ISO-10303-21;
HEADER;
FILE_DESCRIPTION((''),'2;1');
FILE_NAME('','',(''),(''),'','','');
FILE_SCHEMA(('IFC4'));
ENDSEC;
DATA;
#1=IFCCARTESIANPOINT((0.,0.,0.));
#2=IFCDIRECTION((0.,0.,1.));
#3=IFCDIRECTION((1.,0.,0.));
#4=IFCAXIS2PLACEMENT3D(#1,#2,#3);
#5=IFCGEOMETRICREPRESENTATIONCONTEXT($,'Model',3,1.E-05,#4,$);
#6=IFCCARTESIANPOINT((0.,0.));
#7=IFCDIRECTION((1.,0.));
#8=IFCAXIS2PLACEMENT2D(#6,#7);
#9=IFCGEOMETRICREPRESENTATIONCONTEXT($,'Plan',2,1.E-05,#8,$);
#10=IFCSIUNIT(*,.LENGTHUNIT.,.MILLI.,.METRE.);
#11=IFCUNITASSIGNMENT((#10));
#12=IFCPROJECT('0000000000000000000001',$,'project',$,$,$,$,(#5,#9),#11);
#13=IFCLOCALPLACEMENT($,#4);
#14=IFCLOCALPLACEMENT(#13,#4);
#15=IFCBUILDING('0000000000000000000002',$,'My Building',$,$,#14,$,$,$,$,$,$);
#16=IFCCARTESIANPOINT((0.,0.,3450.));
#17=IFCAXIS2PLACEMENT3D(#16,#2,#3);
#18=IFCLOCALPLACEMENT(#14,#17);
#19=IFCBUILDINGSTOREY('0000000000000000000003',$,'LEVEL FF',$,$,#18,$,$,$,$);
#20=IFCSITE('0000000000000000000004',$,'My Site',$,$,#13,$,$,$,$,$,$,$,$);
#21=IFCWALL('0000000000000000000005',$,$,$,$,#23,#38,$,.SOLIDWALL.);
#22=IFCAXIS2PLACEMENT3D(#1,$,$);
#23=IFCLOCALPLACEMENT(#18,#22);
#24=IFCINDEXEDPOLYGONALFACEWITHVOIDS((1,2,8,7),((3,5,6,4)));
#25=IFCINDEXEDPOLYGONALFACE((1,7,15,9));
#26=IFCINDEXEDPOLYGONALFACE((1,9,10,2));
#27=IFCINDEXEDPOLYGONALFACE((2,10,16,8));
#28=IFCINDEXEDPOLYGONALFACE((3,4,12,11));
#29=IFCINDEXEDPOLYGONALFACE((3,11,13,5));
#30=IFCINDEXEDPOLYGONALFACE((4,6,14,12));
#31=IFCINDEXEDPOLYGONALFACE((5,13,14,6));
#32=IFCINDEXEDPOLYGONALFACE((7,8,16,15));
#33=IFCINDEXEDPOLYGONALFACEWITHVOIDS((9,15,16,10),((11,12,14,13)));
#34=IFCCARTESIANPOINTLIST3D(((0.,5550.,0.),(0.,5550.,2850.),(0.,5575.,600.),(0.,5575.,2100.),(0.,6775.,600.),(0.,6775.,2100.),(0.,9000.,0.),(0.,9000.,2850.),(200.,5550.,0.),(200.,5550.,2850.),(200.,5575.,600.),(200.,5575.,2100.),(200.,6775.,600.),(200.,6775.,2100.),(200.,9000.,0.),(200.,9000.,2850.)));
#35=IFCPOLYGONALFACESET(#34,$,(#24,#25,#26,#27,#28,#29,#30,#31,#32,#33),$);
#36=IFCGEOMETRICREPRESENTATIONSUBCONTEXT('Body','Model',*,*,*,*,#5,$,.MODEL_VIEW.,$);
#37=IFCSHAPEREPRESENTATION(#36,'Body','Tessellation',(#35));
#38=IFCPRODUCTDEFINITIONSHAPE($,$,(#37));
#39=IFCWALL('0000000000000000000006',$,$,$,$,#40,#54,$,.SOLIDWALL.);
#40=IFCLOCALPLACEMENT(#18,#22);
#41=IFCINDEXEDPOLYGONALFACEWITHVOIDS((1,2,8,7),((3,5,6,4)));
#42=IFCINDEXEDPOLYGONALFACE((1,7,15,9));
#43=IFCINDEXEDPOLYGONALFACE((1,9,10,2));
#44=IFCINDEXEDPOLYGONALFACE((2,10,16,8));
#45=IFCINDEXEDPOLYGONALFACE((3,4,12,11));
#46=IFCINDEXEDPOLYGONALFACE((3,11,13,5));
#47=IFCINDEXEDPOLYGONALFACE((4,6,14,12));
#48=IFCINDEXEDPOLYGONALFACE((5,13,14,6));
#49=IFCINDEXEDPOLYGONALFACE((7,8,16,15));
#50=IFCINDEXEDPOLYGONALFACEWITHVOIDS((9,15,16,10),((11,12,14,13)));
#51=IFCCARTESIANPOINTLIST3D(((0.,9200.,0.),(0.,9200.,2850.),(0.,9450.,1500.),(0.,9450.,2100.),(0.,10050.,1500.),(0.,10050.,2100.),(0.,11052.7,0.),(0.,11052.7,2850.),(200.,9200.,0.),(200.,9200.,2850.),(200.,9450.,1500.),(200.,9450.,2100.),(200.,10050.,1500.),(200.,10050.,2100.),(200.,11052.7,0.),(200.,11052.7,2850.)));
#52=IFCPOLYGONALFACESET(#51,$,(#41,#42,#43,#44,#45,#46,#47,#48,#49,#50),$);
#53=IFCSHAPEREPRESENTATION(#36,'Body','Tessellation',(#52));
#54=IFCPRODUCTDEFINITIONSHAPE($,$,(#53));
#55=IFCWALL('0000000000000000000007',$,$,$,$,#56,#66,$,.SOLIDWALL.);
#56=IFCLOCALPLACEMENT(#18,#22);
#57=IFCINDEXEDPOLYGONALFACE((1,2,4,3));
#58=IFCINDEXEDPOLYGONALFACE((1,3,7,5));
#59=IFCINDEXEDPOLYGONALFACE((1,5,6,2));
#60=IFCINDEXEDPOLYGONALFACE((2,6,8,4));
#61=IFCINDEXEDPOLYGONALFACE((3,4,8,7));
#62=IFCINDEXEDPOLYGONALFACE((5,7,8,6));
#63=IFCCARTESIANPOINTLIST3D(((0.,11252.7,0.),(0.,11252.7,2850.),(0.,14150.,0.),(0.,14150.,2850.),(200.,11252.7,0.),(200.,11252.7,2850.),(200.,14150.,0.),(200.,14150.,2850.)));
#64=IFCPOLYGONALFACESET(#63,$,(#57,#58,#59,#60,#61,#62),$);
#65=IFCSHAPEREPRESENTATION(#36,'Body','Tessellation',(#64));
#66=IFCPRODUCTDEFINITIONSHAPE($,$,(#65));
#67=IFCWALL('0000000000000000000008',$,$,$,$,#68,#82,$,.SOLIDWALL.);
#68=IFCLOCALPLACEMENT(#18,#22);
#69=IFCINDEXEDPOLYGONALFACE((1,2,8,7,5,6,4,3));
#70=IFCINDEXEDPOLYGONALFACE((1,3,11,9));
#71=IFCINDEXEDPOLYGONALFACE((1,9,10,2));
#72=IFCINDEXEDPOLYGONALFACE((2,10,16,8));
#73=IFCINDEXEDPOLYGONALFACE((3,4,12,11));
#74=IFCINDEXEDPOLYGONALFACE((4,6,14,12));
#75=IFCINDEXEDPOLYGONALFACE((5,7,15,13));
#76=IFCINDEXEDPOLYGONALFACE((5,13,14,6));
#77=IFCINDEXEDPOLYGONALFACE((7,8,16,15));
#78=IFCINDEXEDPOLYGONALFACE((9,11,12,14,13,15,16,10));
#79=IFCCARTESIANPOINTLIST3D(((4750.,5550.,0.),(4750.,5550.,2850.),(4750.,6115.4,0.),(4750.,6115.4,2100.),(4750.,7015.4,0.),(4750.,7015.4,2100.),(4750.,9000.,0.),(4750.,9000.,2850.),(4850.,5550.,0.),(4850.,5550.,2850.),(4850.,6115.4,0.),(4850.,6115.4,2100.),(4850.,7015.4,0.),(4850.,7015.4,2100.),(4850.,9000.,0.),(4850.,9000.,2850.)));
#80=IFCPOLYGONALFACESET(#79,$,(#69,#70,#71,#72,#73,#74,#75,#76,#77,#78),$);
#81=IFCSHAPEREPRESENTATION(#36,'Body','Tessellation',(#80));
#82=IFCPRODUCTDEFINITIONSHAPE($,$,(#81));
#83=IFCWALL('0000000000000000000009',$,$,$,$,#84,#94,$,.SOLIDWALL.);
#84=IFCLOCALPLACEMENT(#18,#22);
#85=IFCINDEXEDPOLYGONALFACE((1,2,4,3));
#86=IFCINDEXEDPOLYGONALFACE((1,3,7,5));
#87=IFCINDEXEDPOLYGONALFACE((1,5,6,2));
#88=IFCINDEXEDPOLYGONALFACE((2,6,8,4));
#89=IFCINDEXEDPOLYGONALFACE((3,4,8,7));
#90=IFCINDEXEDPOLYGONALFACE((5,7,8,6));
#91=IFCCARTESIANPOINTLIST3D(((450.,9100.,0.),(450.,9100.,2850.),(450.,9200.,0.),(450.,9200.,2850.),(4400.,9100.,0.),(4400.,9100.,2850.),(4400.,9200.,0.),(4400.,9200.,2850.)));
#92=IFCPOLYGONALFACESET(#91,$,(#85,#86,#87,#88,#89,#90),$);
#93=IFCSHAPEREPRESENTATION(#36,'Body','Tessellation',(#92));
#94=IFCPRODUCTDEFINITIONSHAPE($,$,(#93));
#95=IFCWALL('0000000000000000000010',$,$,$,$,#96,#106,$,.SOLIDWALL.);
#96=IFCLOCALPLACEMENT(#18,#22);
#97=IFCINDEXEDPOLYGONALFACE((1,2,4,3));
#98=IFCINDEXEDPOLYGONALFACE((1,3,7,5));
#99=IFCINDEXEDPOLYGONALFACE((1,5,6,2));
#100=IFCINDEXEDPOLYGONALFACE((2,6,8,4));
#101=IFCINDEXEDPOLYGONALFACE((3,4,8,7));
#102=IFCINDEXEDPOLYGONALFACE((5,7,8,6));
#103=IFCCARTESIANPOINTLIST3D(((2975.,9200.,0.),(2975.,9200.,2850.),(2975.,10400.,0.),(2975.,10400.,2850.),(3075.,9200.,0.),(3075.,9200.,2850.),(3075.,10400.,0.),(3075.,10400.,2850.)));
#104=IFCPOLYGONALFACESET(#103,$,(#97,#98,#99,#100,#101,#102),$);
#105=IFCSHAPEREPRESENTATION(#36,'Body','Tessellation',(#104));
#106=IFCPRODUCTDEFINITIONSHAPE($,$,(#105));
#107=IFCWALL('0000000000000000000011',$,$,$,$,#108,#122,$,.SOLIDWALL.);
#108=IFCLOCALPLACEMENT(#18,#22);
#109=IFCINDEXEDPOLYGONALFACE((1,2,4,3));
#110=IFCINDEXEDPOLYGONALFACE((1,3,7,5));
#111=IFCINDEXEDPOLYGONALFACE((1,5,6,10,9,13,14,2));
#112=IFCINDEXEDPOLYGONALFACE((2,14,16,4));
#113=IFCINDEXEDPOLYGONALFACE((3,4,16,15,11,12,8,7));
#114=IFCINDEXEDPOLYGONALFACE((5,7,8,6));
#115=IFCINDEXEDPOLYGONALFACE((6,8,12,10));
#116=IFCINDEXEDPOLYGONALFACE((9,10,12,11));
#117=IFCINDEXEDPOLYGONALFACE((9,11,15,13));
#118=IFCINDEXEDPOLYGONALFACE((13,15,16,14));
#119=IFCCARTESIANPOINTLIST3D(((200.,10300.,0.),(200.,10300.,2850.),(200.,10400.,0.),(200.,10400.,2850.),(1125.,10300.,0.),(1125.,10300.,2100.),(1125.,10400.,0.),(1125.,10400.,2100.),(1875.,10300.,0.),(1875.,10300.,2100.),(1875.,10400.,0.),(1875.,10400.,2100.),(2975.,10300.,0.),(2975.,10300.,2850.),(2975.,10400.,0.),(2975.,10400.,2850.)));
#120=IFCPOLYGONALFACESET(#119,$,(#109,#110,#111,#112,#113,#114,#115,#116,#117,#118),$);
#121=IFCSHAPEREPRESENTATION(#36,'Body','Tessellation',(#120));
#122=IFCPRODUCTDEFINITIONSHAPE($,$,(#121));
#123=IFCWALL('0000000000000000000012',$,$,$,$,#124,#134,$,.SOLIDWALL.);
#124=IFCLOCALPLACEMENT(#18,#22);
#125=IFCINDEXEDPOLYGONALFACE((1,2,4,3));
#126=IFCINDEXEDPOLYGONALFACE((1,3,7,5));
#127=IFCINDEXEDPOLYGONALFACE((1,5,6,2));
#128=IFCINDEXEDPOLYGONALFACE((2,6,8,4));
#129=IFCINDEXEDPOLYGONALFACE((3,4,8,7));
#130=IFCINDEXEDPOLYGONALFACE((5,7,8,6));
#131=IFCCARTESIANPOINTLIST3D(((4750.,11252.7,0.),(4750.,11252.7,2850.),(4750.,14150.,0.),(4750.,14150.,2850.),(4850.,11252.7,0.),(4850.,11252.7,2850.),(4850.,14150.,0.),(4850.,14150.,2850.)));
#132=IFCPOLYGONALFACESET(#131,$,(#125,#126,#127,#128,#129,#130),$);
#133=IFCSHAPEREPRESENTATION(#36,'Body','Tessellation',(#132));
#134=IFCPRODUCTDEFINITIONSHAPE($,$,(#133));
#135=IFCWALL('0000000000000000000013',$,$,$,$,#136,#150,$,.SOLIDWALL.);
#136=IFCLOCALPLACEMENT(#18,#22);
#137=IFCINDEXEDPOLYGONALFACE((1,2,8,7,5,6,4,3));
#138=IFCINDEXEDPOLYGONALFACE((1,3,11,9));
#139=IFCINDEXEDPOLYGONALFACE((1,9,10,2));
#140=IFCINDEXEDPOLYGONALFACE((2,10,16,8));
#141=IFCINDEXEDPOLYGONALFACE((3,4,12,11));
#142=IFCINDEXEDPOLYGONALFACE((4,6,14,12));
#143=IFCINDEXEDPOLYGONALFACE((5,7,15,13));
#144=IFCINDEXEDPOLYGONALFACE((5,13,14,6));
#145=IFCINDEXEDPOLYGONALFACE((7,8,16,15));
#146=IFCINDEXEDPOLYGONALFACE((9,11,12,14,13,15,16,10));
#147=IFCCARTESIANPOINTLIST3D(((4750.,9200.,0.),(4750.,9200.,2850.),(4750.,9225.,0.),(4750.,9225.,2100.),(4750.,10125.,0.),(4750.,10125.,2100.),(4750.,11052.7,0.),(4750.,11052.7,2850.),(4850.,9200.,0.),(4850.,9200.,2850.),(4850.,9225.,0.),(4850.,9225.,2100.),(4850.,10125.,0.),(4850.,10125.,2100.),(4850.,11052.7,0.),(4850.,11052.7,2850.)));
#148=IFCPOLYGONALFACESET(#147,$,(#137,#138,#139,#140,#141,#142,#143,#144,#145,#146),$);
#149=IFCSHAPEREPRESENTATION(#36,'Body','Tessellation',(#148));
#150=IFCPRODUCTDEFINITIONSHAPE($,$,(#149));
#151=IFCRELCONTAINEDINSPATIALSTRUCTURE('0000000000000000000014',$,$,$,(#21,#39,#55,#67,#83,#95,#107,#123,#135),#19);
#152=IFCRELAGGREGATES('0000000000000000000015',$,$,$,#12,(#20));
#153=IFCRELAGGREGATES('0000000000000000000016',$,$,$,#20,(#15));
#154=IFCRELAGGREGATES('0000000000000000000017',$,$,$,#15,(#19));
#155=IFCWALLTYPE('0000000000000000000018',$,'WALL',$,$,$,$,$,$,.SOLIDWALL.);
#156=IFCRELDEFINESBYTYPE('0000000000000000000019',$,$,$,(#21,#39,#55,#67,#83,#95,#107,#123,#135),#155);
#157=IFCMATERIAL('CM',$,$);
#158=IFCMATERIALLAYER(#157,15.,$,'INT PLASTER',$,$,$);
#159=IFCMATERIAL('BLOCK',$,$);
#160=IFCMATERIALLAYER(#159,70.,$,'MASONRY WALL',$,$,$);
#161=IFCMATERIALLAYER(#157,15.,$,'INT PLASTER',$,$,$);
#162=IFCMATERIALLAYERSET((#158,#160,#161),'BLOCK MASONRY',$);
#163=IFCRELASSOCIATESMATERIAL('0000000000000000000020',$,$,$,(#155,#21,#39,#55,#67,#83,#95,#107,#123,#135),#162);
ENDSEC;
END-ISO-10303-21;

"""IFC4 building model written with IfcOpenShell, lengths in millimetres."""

from ifc_helpers import new_model, si_unit, frame, origin_with_axes, origin_2d_with_axis, place, context, subcontext, project, spatial, indexed_curve, outline, extrude, material, layer, layer_set, layer_usage, type_object, element, save


model = new_model("IFC4")

# Units and contexts
model_context = context("Model", 3, precision=1e-05, world=origin_with_axes())
plan_context = context("Plan", 2, precision=1e-05, world=origin_2d_with_axis())
body_context = subcontext(model_context, "Body", "Model", "MODEL_VIEW")
ifc_project = project(units=[si_unit("LENGTHUNIT", "METRE", prefix="MILLI")], contexts=[model_context, plan_context])

# Site, building, storey
site_placement = place(None, origin_with_axes())
site = spatial("IfcSite", under=ifc_project, at=site_placement, Name="My Site")
building_placement = place(site_placement, origin_with_axes())
building = spatial("IfcBuilding", under=site, at=building_placement, Name="My Building")
storey_placement = place(building_placement, frame((0.0, 0.0, 3450.0), z_axis=(0.0, 0.0, 1.0), x_axis=(1.0, 0.0, 0.0)))
storey = spatial("IfcBuildingStorey", under=building, at=storey_placement, Name="LEVEL FF")

# Shared definitions
ifc_material_1 = material(Name="CM")
ifc_layer_1 = layer(ifc_material_1, 15.0, Name="INT PLASTER")
ifc_material_2 = material(Name="BLOCK")
ifc_layer_2 = layer(ifc_material_2, 70.0, Name="MASONRY WALL")
ifc_layer_3 = layer(ifc_material_1, 15.0, Name="INT PLASTER")
ifc_layer_set = layer_set([ifc_layer_1, ifc_layer_2, ifc_layer_3], Name="BLOCK MASONRY")
wall_type = type_object("IfcWallType", Name="WALL", PredefinedType="SOLIDWALL", material=ifc_layer_set)

# Walls, openings
ifc_layer_usage_1 = layer_usage(ifc_layer_set, "AXIS2", "POSITIVE", 0.0)
wall_1_placement = place(storey_placement, frame((200.0, 5550.0, 0.0), z_axis=(0.0, 0.0, 1.0), x_axis=(0.0, 1.0, 0.0)))
wall_1 = element("IfcWall", 1, at=wall_1_placement, inside=storey, type_object=wall_type, material=ifc_layer_usage_1, PredefinedType="SOLIDWALL", context=body_context, shape_type="SweptSolid", body=[
    extrude(outline(indexed_curve([(0.0, 0.0), (0.0, 200.0), (3450.0, 200.0), (3450.0, 0.0), (0.0, 0.0)], self_intersect=False)), origin_with_axes(), (0.0, 0.0, 1.0), 2850.0),
])
opening_1_placement = place(wall_1_placement, frame((25.0, 0.0, 600.0), z_axis=(0.0, 0.0, 1.0), x_axis=(1.0, 0.0, 0.0)))
element("IfcOpeningElement", 2, at=opening_1_placement, cuts=wall_1, PredefinedType="OPENING", context=body_context, shape_type="SweptSolid", body=[
    extrude(outline(indexed_curve([(0.0, 0.0), (0.0, 400.0), (1200.0, 400.0), (1200.0, 0.0), (0.0, 0.0)], self_intersect=False)), frame((0.0, -100.0, 0.0), z_axis=(0.0, 0.0, 1.0), x_axis=(1.0, 0.0, 0.0)), (0.0, 0.0, 1.0), 1500.0),
])
ifc_layer_usage_2 = layer_usage(ifc_layer_set, "AXIS2", "POSITIVE", 0.0)
wall_2_placement = place(storey_placement, frame((200.0, 9200.0, 0.0), z_axis=(0.0, 0.0, 1.0), x_axis=(0.0, 1.0, 0.0)))
wall_2 = element("IfcWall", 3, at=wall_2_placement, inside=storey, type_object=wall_type, material=ifc_layer_usage_2, PredefinedType="SOLIDWALL", context=body_context, shape_type="SweptSolid", body=[
    extrude(outline(indexed_curve([(0.0, 0.0), (0.0, 200.0), (1852.7, 200.0), (1852.7, 0.0), (0.0, 0.0)], self_intersect=False)), origin_with_axes(), (0.0, 0.0, 1.0), 2850.0),
])
opening_2_placement = place(wall_2_placement, frame((250.0, 0.0, 1500.0), z_axis=(0.0, 0.0, 1.0), x_axis=(1.0, 0.0, 0.0)))
element("IfcOpeningElement", 4, at=opening_2_placement, cuts=wall_2, PredefinedType="OPENING", context=body_context, shape_type="SweptSolid", body=[
    extrude(outline(indexed_curve([(0.0, 0.0), (0.0, 400.0), (600.0, 400.0), (600.0, 0.0), (0.0, 0.0)], self_intersect=False)), frame((0.0, -100.0, 0.0), z_axis=(0.0, 0.0, 1.0), x_axis=(1.0, 0.0, 0.0)), (0.0, 0.0, 1.0), 600.0),
])

# Wall
ifc_layer_usage_3 = layer_usage(ifc_layer_set, "AXIS2", "POSITIVE", 0.0)
wall_3_placement = place(storey_placement, frame((200.0, 11252.7, 0.0), z_axis=(0.0, 0.0, 1.0), x_axis=(0.0, 1.0, 0.0)))
element("IfcWall", 5, at=wall_3_placement, inside=storey, type_object=wall_type, material=ifc_layer_usage_3, PredefinedType="SOLIDWALL", context=body_context, shape_type="SweptSolid", body=[
    extrude(outline(indexed_curve([(0.0, 0.0), (0.0, 200.0), (2897.3, 200.0), (2897.3, 0.0), (0.0, 0.0)], self_intersect=False)), origin_with_axes(), (0.0, 0.0, 1.0), 2850.0),
])

# Wall, opening
ifc_layer_usage_4 = layer_usage(ifc_layer_set, "AXIS2", "POSITIVE", 0.0)
wall_4_placement = place(storey_placement, frame((4850.0, 5550.0, 0.0), z_axis=(0.0, 0.0, 1.0), x_axis=(0.0, 1.0, 0.0)))
wall_4 = element("IfcWall", 6, at=wall_4_placement, inside=storey, type_object=wall_type, material=ifc_layer_usage_4, PredefinedType="SOLIDWALL", context=body_context, shape_type="SweptSolid", body=[
    extrude(outline(indexed_curve([(0.0, 0.0), (0.0, 100.0), (3450.0, 100.0), (3450.0, 0.0), (0.0, 0.0)], self_intersect=False)), origin_with_axes(), (0.0, 0.0, 1.0), 2850.0),
])
opening_3_placement = place(wall_4_placement, frame((565.4, 0.0, 0.0), z_axis=(0.0, 0.0, 1.0), x_axis=(1.0, 0.0, 0.0)))
element("IfcOpeningElement", 7, at=opening_3_placement, cuts=wall_4, PredefinedType="OPENING", context=body_context, shape_type="SweptSolid", body=[
    extrude(outline(indexed_curve([(0.0, 0.0), (0.0, 400.0), (900.0, 400.0), (900.0, 0.0), (0.0, 0.0)], self_intersect=False)), frame((0.0, -100.0, 0.0), z_axis=(0.0, 0.0, 1.0), x_axis=(1.0, 0.0, 0.0)), (0.0, 0.0, 1.0), 2100.0),
])

# Walls
ifc_layer_usage_5 = layer_usage(ifc_layer_set, "AXIS2", "POSITIVE", 0.0)
wall_5_placement = place(storey_placement, frame((450.0, 9200.0, 0.0), z_axis=(0.0, 0.0, 1.0), x_axis=(0.0, -1.0, 0.0)))
element("IfcWall", 8, at=wall_5_placement, inside=storey, type_object=wall_type, material=ifc_layer_usage_5, PredefinedType="SOLIDWALL", context=body_context, shape_type="SweptSolid", body=[
    extrude(outline(indexed_curve([(0.0, 0.0), (0.0, 3950.0), (100.0, 3950.0), (100.0, 0.0), (0.0, 0.0)], self_intersect=False)), origin_with_axes(), (0.0, 0.0, 1.0), 2850.0),
])
ifc_layer_usage_6 = layer_usage(ifc_layer_set, "AXIS2", "POSITIVE", 0.0)
wall_6_placement = place(storey_placement, frame((3075.0, 9200.0, 0.0), z_axis=(0.0, 0.0, 1.0), x_axis=(0.0, 1.0, 0.0)))
element("IfcWall", 9, at=wall_6_placement, inside=storey, type_object=wall_type, material=ifc_layer_usage_6, PredefinedType="SOLIDWALL", context=body_context, shape_type="SweptSolid", body=[
    extrude(outline(indexed_curve([(0.0, 0.0), (0.0, 100.0), (1200.0, 100.0), (1200.0, 0.0), (0.0, 0.0)], self_intersect=False)), origin_with_axes(), (0.0, 0.0, 1.0), 2850.0),
])

# Wall, opening
ifc_layer_usage_7 = layer_usage(ifc_layer_set, "AXIS2", "POSITIVE", 0.0)
wall_7_placement = place(storey_placement, frame((200.0, 10400.0, 0.0), z_axis=(0.0, 0.0, 1.0), x_axis=(0.0, -1.0, 0.0)))
wall_7 = element("IfcWall", 10, at=wall_7_placement, inside=storey, type_object=wall_type, material=ifc_layer_usage_7, PredefinedType="SOLIDWALL", context=body_context, shape_type="SweptSolid", body=[
    extrude(outline(indexed_curve([(0.0, 0.0), (0.0, 2775.0), (100.0, 2775.0), (100.0, 0.0), (0.0, 0.0)], self_intersect=False)), origin_with_axes(), (0.0, 0.0, 1.0), 2850.0),
])
opening_4_placement = place(wall_7_placement, frame((0.0, 1675.0, 0.0), z_axis=(0.0, 0.0, 1.0), x_axis=(0.0, -1.0, 0.0)))
element("IfcOpeningElement", 11, at=opening_4_placement, cuts=wall_7, PredefinedType="OPENING", context=body_context, shape_type="SweptSolid", body=[
    extrude(outline(indexed_curve([(0.0, 0.0), (0.0, 400.0), (750.0, 400.0), (750.0, 0.0), (0.0, 0.0)], self_intersect=False)), frame((0.0, -100.0, 0.0), z_axis=(0.0, 0.0, 1.0), x_axis=(1.0, 0.0, 0.0)), (0.0, 0.0, 1.0), 2100.0),
])

# Wall
ifc_layer_usage_8 = layer_usage(ifc_layer_set, "AXIS2", "POSITIVE", 0.0)
wall_8_placement = place(storey_placement, frame((4850.0, 11252.7, 0.0), z_axis=(0.0, 0.0, 1.0), x_axis=(0.0, 1.0, 0.0)))
element("IfcWall", 12, at=wall_8_placement, inside=storey, type_object=wall_type, material=ifc_layer_usage_8, PredefinedType="SOLIDWALL", context=body_context, shape_type="SweptSolid", body=[
    extrude(outline(indexed_curve([(0.0, 0.0), (0.0, 100.0), (2897.3, 100.0), (2897.3, 0.0), (0.0, 0.0)], self_intersect=False)), origin_with_axes(), (0.0, 0.0, 1.0), 2850.0),
])

# Wall, opening
ifc_layer_usage_9 = layer_usage(ifc_layer_set, "AXIS2", "POSITIVE", 0.0)
wall_9_placement = place(storey_placement, frame((4850.0, 9200.0, 0.0), z_axis=(0.0, 0.0, 1.0), x_axis=(0.0, 1.0, 0.0)))
wall_9 = element("IfcWall", 13, at=wall_9_placement, inside=storey, type_object=wall_type, material=ifc_layer_usage_9, PredefinedType="SOLIDWALL", context=body_context, shape_type="SweptSolid", body=[
    extrude(outline(indexed_curve([(0.0, 0.0), (0.0, 100.0), (1852.7, 100.0), (1852.7, 0.0), (0.0, 0.0)], self_intersect=False)), origin_with_axes(), (0.0, 0.0, 1.0), 2850.0),
])
opening_5_placement = place(wall_9_placement, frame((25.0, 0.0, 0.0), z_axis=(0.0, 0.0, 1.0), x_axis=(1.0, 0.0, 0.0)))
element("IfcOpeningElement", 14, at=opening_5_placement, cuts=wall_9, PredefinedType="OPENING", context=body_context, shape_type="SweptSolid", body=[
    extrude(outline(indexed_curve([(0.0, 0.0), (0.0, 400.0), (900.0, 400.0), (900.0, 0.0), (0.0, 0.0)], self_intersect=False)), frame((0.0, -100.0, 0.0), z_axis=(0.0, 0.0, 1.0), x_axis=(1.0, 0.0, 0.0)), (0.0, 0.0, 1.0), 2100.0),
])

save(model, "model.ifc")
